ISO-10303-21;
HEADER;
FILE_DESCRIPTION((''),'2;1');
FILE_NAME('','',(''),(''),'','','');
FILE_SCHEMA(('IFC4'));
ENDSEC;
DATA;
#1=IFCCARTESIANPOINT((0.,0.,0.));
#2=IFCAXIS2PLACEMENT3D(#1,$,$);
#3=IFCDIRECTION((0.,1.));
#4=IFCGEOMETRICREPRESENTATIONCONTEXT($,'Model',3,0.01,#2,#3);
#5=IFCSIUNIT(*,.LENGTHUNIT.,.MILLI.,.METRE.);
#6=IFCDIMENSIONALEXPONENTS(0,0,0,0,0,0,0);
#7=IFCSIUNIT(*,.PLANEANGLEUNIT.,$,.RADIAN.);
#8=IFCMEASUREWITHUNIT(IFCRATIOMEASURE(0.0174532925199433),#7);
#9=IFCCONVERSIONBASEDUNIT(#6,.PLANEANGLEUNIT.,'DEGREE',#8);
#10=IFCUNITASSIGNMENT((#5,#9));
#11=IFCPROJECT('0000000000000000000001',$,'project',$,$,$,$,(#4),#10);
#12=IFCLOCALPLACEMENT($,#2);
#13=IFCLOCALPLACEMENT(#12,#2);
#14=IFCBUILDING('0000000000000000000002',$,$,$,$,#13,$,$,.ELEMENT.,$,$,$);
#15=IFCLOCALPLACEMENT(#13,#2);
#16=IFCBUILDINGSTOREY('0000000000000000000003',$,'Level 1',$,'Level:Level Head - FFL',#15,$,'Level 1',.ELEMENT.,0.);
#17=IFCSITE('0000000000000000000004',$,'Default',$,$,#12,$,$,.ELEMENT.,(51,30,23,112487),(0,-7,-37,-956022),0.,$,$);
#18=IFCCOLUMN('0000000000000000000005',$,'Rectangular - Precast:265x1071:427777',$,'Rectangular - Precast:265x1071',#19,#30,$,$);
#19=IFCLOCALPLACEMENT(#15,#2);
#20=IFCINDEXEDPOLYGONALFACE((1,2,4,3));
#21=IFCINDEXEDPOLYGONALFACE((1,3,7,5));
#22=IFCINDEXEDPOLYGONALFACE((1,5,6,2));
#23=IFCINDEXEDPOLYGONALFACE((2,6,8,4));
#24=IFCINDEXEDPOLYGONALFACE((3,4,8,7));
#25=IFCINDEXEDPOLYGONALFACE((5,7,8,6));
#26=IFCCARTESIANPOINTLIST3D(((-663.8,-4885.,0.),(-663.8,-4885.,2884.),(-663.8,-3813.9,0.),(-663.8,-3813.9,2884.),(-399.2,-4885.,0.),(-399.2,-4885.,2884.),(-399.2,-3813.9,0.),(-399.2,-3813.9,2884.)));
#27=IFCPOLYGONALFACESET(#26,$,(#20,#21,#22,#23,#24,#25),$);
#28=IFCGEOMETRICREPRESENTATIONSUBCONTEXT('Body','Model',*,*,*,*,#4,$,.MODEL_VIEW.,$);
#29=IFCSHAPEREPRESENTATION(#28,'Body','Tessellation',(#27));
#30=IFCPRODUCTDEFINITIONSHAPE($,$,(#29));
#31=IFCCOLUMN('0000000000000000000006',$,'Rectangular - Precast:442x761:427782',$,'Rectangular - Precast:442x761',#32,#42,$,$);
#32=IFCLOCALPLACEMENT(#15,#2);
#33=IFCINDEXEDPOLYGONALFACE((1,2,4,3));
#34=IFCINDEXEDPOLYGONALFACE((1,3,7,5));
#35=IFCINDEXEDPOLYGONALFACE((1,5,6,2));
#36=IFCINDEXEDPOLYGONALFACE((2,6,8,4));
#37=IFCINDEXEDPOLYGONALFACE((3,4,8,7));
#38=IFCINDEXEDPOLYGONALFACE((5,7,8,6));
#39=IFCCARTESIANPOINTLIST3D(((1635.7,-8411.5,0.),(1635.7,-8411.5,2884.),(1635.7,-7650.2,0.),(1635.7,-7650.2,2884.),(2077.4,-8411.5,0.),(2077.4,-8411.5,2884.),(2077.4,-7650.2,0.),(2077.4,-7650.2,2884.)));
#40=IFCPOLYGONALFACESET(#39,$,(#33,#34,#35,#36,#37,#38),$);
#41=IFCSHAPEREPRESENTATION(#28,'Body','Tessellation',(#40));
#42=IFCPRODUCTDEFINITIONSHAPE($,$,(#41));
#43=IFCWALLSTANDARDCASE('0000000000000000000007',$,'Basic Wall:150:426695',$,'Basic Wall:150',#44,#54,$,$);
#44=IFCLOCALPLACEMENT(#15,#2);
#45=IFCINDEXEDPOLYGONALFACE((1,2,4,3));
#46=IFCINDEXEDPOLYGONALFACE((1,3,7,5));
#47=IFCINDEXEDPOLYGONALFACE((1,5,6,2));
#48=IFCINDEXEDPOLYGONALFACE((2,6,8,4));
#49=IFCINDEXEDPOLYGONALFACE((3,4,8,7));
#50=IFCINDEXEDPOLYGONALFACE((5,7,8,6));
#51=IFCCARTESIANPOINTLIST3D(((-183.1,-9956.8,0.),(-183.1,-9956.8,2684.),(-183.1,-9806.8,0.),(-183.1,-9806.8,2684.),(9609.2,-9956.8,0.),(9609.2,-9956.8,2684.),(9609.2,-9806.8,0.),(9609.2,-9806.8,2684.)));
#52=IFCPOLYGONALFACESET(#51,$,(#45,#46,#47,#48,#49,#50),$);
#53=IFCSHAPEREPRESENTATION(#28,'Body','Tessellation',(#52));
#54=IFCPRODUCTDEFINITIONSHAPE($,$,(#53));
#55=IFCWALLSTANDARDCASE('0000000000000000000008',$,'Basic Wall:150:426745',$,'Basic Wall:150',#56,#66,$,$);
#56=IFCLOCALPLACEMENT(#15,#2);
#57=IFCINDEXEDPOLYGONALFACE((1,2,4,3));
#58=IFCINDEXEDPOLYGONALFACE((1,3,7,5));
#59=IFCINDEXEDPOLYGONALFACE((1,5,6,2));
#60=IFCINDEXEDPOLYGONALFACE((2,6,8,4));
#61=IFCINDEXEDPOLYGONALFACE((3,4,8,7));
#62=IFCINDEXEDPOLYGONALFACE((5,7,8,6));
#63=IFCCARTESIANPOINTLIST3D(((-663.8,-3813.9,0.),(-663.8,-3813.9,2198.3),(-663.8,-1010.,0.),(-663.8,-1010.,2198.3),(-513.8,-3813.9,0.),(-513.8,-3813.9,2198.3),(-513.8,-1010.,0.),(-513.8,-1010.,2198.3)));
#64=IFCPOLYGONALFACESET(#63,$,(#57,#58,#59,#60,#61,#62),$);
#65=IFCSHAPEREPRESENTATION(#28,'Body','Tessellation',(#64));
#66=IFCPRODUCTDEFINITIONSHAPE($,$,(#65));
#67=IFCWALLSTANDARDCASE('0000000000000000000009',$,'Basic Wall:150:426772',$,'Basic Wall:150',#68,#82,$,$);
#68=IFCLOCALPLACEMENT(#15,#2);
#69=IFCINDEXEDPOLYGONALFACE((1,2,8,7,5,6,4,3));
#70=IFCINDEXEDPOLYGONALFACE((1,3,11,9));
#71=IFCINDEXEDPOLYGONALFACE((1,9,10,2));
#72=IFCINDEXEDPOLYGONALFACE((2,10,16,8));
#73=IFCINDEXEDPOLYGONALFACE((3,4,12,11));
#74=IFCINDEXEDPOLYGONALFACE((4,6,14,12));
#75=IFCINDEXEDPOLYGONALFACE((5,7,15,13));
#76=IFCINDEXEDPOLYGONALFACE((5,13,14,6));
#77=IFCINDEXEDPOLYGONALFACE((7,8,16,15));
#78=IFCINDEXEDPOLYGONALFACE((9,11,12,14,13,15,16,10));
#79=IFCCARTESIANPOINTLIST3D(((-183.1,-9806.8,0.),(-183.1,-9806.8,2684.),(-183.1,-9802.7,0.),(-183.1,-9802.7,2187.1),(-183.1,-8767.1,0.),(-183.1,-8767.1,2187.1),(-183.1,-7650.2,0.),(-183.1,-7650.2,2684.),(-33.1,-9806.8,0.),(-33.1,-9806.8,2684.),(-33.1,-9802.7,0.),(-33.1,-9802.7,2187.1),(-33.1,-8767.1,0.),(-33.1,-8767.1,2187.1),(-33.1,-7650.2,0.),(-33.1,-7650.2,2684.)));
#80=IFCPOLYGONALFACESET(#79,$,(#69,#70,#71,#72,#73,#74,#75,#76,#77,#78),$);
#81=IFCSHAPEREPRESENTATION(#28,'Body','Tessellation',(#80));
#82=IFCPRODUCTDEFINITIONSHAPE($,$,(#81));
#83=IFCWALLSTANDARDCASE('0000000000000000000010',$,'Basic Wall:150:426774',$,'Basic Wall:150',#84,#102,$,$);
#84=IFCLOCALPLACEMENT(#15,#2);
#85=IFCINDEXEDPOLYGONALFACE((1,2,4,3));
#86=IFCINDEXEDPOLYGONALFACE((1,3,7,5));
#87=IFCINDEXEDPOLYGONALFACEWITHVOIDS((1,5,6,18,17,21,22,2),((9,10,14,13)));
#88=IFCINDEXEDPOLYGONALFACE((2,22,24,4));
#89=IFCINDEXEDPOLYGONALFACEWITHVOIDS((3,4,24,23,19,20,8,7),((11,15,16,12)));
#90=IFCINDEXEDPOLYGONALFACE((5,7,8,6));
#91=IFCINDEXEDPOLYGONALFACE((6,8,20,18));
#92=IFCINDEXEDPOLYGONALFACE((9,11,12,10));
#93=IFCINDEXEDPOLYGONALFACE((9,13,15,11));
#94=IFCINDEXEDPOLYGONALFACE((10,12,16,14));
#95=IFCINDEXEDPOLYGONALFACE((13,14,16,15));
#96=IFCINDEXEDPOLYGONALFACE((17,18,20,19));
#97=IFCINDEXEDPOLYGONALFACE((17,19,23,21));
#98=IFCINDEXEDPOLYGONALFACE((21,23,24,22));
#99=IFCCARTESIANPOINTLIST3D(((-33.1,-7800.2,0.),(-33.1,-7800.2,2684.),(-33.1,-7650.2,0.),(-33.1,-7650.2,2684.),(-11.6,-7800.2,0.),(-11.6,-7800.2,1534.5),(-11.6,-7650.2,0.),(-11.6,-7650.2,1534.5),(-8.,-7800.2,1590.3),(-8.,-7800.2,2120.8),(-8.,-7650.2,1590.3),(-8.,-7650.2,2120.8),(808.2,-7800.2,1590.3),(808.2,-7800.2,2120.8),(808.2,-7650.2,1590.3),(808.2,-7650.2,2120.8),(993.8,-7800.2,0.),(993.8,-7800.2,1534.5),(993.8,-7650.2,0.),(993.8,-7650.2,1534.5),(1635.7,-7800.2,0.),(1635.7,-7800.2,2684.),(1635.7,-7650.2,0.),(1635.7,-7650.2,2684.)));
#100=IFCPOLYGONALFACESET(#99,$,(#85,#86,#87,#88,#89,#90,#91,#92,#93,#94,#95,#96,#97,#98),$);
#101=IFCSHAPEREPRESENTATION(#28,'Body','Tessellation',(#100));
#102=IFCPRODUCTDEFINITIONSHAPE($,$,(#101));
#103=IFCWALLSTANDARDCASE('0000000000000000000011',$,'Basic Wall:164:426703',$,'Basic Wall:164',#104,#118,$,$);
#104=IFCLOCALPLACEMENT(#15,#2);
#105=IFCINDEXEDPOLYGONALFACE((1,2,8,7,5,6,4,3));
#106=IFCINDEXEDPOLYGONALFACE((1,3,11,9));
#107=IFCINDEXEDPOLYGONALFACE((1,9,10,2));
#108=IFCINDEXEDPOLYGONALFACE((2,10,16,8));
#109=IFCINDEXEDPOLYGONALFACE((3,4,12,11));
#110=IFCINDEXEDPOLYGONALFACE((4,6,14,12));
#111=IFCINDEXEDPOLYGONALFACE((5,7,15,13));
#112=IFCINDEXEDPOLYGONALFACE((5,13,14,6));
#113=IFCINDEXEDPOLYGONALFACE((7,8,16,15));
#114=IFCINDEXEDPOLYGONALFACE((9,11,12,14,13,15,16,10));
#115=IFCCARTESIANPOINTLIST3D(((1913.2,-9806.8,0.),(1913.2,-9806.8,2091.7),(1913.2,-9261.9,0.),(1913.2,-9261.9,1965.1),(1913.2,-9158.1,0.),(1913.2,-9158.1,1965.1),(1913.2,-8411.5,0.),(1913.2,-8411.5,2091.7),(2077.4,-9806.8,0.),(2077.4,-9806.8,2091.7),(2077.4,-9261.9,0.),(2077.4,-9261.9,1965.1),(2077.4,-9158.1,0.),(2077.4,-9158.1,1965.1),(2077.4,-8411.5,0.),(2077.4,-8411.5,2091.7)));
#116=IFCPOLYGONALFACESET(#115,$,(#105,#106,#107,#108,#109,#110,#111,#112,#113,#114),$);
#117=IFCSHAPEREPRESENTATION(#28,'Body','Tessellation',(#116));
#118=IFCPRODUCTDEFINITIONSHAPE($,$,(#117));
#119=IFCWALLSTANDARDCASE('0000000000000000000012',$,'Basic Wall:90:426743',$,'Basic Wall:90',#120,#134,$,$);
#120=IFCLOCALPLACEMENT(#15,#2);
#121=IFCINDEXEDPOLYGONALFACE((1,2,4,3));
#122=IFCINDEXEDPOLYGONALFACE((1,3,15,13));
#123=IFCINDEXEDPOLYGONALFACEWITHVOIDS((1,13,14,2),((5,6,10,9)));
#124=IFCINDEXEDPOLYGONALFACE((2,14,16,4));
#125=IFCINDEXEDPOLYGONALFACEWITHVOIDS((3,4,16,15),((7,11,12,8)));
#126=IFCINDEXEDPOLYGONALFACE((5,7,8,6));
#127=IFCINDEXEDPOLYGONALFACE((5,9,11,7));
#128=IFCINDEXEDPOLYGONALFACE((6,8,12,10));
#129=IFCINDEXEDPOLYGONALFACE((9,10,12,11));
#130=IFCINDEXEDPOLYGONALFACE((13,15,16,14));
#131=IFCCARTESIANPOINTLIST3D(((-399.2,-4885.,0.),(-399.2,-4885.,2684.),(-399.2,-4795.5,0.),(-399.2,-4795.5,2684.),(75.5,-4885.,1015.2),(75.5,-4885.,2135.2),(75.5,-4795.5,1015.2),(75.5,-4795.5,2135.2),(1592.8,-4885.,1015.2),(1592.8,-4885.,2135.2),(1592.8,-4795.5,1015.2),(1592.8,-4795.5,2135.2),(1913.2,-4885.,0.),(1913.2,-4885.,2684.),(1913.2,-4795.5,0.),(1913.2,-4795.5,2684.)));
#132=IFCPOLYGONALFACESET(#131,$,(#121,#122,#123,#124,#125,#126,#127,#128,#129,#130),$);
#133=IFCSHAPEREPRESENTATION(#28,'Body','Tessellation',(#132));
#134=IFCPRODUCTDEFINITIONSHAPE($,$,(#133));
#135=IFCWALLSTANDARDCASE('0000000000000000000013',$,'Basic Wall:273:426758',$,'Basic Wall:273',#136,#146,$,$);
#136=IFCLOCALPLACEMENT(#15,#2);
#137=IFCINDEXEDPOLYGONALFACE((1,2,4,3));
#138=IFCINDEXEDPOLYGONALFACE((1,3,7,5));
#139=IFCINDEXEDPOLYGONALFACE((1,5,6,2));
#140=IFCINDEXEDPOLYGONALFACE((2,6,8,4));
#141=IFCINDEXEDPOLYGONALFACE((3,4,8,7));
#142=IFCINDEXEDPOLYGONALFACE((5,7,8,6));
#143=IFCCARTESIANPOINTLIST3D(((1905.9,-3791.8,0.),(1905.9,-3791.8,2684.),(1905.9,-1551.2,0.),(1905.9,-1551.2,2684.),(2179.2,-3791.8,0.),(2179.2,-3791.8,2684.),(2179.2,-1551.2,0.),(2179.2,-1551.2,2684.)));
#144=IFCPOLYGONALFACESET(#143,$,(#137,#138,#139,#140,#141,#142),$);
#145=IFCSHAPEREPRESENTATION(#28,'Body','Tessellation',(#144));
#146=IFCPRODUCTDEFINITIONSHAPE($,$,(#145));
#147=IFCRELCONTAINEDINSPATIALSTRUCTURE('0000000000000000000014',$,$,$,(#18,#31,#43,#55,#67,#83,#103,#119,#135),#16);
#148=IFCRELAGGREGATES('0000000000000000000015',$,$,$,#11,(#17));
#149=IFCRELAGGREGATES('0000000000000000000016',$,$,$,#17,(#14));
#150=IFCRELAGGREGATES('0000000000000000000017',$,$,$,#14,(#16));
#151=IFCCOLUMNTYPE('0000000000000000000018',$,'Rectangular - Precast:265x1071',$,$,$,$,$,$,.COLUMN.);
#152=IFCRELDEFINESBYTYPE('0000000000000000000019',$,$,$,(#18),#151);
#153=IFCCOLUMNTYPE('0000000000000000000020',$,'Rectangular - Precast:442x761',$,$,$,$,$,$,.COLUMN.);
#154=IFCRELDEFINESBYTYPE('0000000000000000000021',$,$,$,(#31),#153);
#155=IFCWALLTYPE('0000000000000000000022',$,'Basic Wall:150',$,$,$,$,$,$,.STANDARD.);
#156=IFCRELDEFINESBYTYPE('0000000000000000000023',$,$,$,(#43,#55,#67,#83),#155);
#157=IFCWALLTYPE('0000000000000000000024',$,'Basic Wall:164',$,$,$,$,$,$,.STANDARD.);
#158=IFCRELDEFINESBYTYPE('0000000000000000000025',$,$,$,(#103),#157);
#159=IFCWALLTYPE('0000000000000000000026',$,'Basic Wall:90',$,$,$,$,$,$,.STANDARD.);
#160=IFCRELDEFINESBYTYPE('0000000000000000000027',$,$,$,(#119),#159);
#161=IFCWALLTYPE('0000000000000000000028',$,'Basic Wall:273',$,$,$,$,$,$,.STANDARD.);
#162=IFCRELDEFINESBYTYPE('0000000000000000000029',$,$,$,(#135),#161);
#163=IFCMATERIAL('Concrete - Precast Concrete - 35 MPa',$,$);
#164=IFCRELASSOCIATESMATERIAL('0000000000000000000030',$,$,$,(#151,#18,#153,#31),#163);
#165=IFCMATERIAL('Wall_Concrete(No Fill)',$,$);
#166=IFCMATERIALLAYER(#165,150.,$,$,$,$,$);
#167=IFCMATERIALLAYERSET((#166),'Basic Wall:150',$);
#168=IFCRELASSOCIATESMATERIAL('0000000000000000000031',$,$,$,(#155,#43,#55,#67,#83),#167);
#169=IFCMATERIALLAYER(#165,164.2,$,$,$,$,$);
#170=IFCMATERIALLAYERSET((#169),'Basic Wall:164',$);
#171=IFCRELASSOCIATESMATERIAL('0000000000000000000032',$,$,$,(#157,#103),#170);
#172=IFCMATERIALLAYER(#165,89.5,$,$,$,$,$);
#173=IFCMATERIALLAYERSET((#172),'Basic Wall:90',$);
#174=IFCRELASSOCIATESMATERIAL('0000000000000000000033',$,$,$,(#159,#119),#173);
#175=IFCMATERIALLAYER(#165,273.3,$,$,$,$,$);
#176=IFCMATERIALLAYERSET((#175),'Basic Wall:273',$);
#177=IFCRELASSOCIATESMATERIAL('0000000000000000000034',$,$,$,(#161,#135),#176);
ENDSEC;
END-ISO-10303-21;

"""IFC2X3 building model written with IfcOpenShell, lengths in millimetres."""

from ifc_helpers import new_model, entity, si_unit, converted_unit, direction, frame, frame_2d, origin, origin_2d_with_axis, place, context, subcontext, project, spatial, rectangle, extrude, source, transform, mapped, material, layer, layer_set, layer_usage, type_object, type_shapes, element, save


model = new_model("IFC2X3")

# Units and contexts
model_context = context("Model", 3, precision=0.01, world=origin(), true_north=direction((0.0, 1.0)))
body_context = subcontext(model_context, "Body", "Model", "MODEL_VIEW")
ifc_project = project(units=[si_unit("LENGTHUNIT", "METRE", prefix="MILLI"), converted_unit("PLANEANGLEUNIT", "DEGREE", entity("IfcRatioMeasure", 0.0174532925199433), si_unit("PLANEANGLEUNIT", "RADIAN"), dimensions=[0, 0, 0, 0, 0, 0, 0])], contexts=[model_context])

# Site, building, storey
site_placement = place(None, origin())
site = spatial("IfcSite", under=ifc_project, at=site_placement, Name="Default", CompositionType="ELEMENT", RefLatitude=(51, 30, 23, 112487), RefLongitude=(0, -7, -37, -956022), RefElevation=0.0)
building_placement = place(site_placement, origin())
building = spatial("IfcBuilding", under=site, at=building_placement, CompositionType="ELEMENT")
storey_placement = place(building_placement, origin())
storey = spatial("IfcBuildingStorey", under=building, at=storey_placement, Name="Level 1", ObjectType="Level:Level Head - FFL", LongName="Level 1", CompositionType="ELEMENT", Elevation=0.0)

# Columns
ifc_material_1 = material(Name="Concrete - Precast Concrete - 35 MPa")
column_type_1 = type_object("IfcColumnType", Name="Rectangular - Precast:265x1071", PredefinedType="COLUMN", material=ifc_material_1)
shared_shape_1 = source(origin(), body_context, "Body", "SweptSolid", [
    extrude(rectangle(XDim=1071.1, YDim=264.6, at=frame_2d((0.0, 0.0), x_axis=(1.0, 0.0))), frame((0.0, 0.0, 0.0), z_axis=(0.0, 0.0, 1.0), x_axis=(0.0, -1.0, 0.0)), (0.0, 0.0, 1.0), 2884.0),
])
type_shapes(column_type_1, [shared_shape_1])
column_1_placement = place(storey_placement, frame((-531.5, -4349.4, 0.0)))
element("IfcColumn", 1, at=column_1_placement, inside=storey, type_object=column_type_1, material=ifc_material_1, Name="Rectangular - Precast:265x1071:427777", ObjectType="Rectangular - Precast:265x1071", context=body_context, shape_type="MappedRepresentation", body=[
    mapped(shared_shape_1, transform((0.0, 0.0, 0.0), scale=1.0)),
])
column_type_2 = type_object("IfcColumnType", Name="Rectangular - Precast:442x761", PredefinedType="COLUMN", material=ifc_material_1)
shared_shape_2 = source(origin(), body_context, "Body", "SweptSolid", [
    extrude(rectangle(XDim=761.3, YDim=441.8, at=frame_2d((0.0, 0.0), x_axis=(1.0, 0.0))), frame((0.0, 0.0, 0.0), z_axis=(0.0, 0.0, 1.0), x_axis=(0.0, -1.0, 0.0)), (0.0, 0.0, 1.0), 2884.0),
])
type_shapes(column_type_2, [shared_shape_2])
column_2_placement = place(storey_placement, frame((1856.6, -8030.8, 0.0)))
element("IfcColumn", 2, at=column_2_placement, inside=storey, type_object=column_type_2, material=ifc_material_1, Name="Rectangular - Precast:442x761:427782", ObjectType="Rectangular - Precast:442x761", context=body_context, shape_type="MappedRepresentation", body=[
    mapped(shared_shape_2, transform((0.0, 0.0, 0.0), scale=1.0)),
])

# Shared definitions
ifc_material_2 = material(Name="Wall_Concrete(No Fill)")

# Wall
ifc_layer_1 = layer(ifc_material_2, 150.0)
ifc_layer_set_1 = layer_set([ifc_layer_1], Name="Basic Wall:150")
ifc_layer_usage_1 = layer_usage(ifc_layer_set_1, "AXIS2", "NEGATIVE", 75.0)
wall_type_1 = type_object("IfcWallType", Name="Basic Wall:150", PredefinedType="STANDARD", material=ifc_layer_set_1)
wall_1_placement = place(storey_placement, frame((-183.1, -9881.8, 0.0)))
element("IfcWallStandardCase", 3, at=wall_1_placement, inside=storey, type_object=wall_type_1, material=ifc_layer_usage_1, Name="Basic Wall:150:426695", ObjectType="Basic Wall:150", context=body_context, shape_type="SweptSolid", body=[
    extrude(rectangle(XDim=9792.4, YDim=150.0, at=frame_2d((4896.2, 0.0), x_axis=(-1.0, 0.0))), origin(), (0.0, 0.0, 1.0), 2684.0),
])

# Walls, openings
ifc_layer_usage_2 = layer_usage(ifc_layer_set_1, "AXIS2", "NEGATIVE", 75.0)
wall_2_placement = place(storey_placement, frame((-588.8, -3813.9, 0.0), z_axis=(0.0, 0.0, 1.0), x_axis=(0.0, 1.0, 0.0)))
wall_2 = element("IfcWallStandardCase", 4, at=wall_2_placement, inside=storey, type_object=wall_type_1, material=ifc_layer_usage_2, Name="Basic Wall:150:426745", ObjectType="Basic Wall:150", context=body_context, shape_type="SweptSolid", body=[
    extrude(rectangle(XDim=2803.9, YDim=150.0, at=frame_2d((1401.9, 0.0), x_axis=(-1.0, 0.0))), origin(), (0.0, 0.0, 1.0), 2198.3),
])
opening_1_placement = place(wall_2_placement, origin())
element("IfcOpeningElement", 5, at=opening_1_placement, cuts=wall_2, ObjectType="Opening", context=body_context, shape_type="SweptSolid", body=[
    extrude(rectangle(XDim=685.7, YDim=2803.9, at=frame_2d((0.0, 0.0), x_axis=(1.0, 0.0))), frame((1401.9, -75.0, 2541.2), z_axis=(0.0, 1.0, 0.0), x_axis=(0.0, 0.0, -1.0)), (0.0, 0.0, 1.0), 150.0),
])
ifc_layer_usage_3 = layer_usage(ifc_layer_set_1, "AXIS2", "NEGATIVE", 75.0)
wall_3_placement = place(storey_placement, frame((-108.1, -9806.8, 0.0), z_axis=(0.0, 0.0, 1.0), x_axis=(0.0, 1.0, 0.0)))
wall_3 = element("IfcWallStandardCase", 6, at=wall_3_placement, inside=storey, type_object=wall_type_1, material=ifc_layer_usage_3, Name="Basic Wall:150:426772", ObjectType="Basic Wall:150", context=body_context, shape_type="SweptSolid", body=[
    extrude(rectangle(XDim=2156.7, YDim=150.0, at=frame_2d((1078.3, 0.0), x_axis=(-1.0, 0.0))), origin(), (0.0, 0.0, 1.0), 2684.0),
])
opening_2_placement = place(wall_3_placement, origin())
element("IfcOpeningElement", 7, at=opening_2_placement, cuts=wall_3, ObjectType="Opening", context=body_context, shape_type="SweptSolid", body=[
    extrude(rectangle(XDim=2187.1, YDim=1035.6, at=origin_2d_with_axis()), frame((521.9, -75.0, 1093.5), z_axis=(0.0, 1.0, 0.0), x_axis=(0.0, 0.0, -1.0)), (0.0, 0.0, 1.0), 150.0),
])

# Walls, openings
ifc_layer_usage_4 = layer_usage(ifc_layer_set_1, "AXIS2", "NEGATIVE", 75.0)
wall_4_placement = place(storey_placement, frame((-33.1, -7725.2, 0.0)))
wall_4 = element("IfcWallStandardCase", 8, at=wall_4_placement, inside=storey, type_object=wall_type_1, material=ifc_layer_usage_4, Name="Basic Wall:150:426774", ObjectType="Basic Wall:150", context=body_context, shape_type="SweptSolid", body=[
    extrude(rectangle(XDim=1668.8, YDim=150.0, at=frame_2d((834.4, 0.0), x_axis=(-1.0, 0.0))), origin(), (0.0, 0.0, 1.0), 2684.0),
])
opening_3_placement = place(wall_4_placement, origin())
element("IfcOpeningElement", 9, at=opening_3_placement, cuts=wall_4, ObjectType="Opening", context=body_context, shape_type="SweptSolid", body=[
    extrude(rectangle(XDim=1534.5, YDim=1005.4, at=origin_2d_with_axis()), frame((524.2, -75.0, 767.2), z_axis=(0.0, 1.0, 0.0), x_axis=(0.0, 0.0, -1.0)), (0.0, 0.0, 1.0), 150.0),
])
opening_4_placement = place(wall_4_placement, origin())
element("IfcOpeningElement", 10, at=opening_4_placement, cuts=wall_4, ObjectType="Opening", context=body_context, shape_type="SweptSolid", body=[
    extrude(rectangle(XDim=530.5, YDim=816.3, at=frame_2d((0.0, 0.0), x_axis=(1.0, 0.0))), frame((433.2, -75.0, 1855.5), z_axis=(0.0, 1.0, 0.0), x_axis=(0.0, 0.0, -1.0)), (0.0, 0.0, 1.0), 150.0),
])
ifc_layer_2 = layer(ifc_material_2, 164.2)
ifc_layer_set_2 = layer_set([ifc_layer_2], Name="Basic Wall:164")
ifc_layer_usage_5 = layer_usage(ifc_layer_set_2, "AXIS2", "NEGATIVE", 82.1)
wall_type_2 = type_object("IfcWallType", Name="Basic Wall:164", PredefinedType="STANDARD", material=ifc_layer_set_2)
wall_5_placement = place(storey_placement, frame((1995.3, -9806.8, 0.0), z_axis=(0.0, 0.0, 1.0), x_axis=(0.0, 1.0, 0.0)))
wall_5 = element("IfcWallStandardCase", 11, at=wall_5_placement, inside=storey, type_object=wall_type_2, material=ifc_layer_usage_5, Name="Basic Wall:164:426703", ObjectType="Basic Wall:164", context=body_context, shape_type="SweptSolid", body=[
    extrude(rectangle(XDim=1395.3, YDim=164.2, at=frame_2d((697.7, 0.0), x_axis=(-1.0, 0.0))), origin(), (0.0, 0.0, 1.0), 2091.7),
])
opening_5_placement = place(wall_5_placement, origin())
element("IfcOpeningElement", 12, at=opening_5_placement, cuts=wall_5, ObjectType="Opening", context=body_context, shape_type="SweptSolid", body=[
    extrude(rectangle(XDim=792.3, YDim=1395.3, at=origin_2d_with_axis()), frame((697.7, -82.1, 2487.8), z_axis=(0.0, 1.0, 0.0), x_axis=(0.0, 0.0, -1.0)), (0.0, 0.0, 1.0), 164.2),
])
opening_6_placement = place(wall_5_placement, origin())
element("IfcOpeningElement", 13, at=opening_6_placement, cuts=wall_5, ObjectType="Opening", context=body_context, shape_type="SweptSolid", body=[
    extrude(rectangle(XDim=1965.1, YDim=103.9, at=origin_2d_with_axis()), frame((596.8, -82.1, 982.5), z_axis=(0.0, 1.0, 0.0), x_axis=(0.0, 0.0, -1.0)), (0.0, 0.0, 1.0), 164.2),
])

# Wall, opening
ifc_layer_3 = layer(ifc_material_2, 89.5)
ifc_layer_set_3 = layer_set([ifc_layer_3], Name="Basic Wall:90")
ifc_layer_usage_6 = layer_usage(ifc_layer_set_3, "AXIS2", "NEGATIVE", 44.8)
wall_type_3 = type_object("IfcWallType", Name="Basic Wall:90", PredefinedType="STANDARD", material=ifc_layer_set_3)
wall_6_placement = place(storey_placement, frame((-399.2, -4840.2, 0.0)))
wall_6 = element("IfcWallStandardCase", 14, at=wall_6_placement, inside=storey, type_object=wall_type_3, material=ifc_layer_usage_6, Name="Basic Wall:90:426743", ObjectType="Basic Wall:90", context=body_context, shape_type="SweptSolid", body=[
    extrude(rectangle(XDim=2312.4, YDim=89.5, at=frame_2d((1156.2, 0.0), x_axis=(-1.0, 0.0))), origin(), (0.0, 0.0, 1.0), 2684.0),
])
opening_7_placement = place(wall_6_placement, origin())
element("IfcOpeningElement", 15, at=opening_7_placement, cuts=wall_6, ObjectType="Opening", context=body_context, shape_type="SweptSolid", body=[
    extrude(rectangle(XDim=1120.0, YDim=1517.3, at=frame_2d((0.0, 0.0), x_axis=(1.0, 0.0))), frame((1233.4, -44.8, 1575.2), z_axis=(0.0, 1.0, 0.0), x_axis=(0.0, 0.0, -1.0)), (0.0, 0.0, 1.0), 89.5),
])

# Wall
ifc_layer_4 = layer(ifc_material_2, 273.3)
ifc_layer_set_4 = layer_set([ifc_layer_4], Name="Basic Wall:273")
ifc_layer_usage_7 = layer_usage(ifc_layer_set_4, "AXIS2", "NEGATIVE", 136.6)
wall_type_4 = type_object("IfcWallType", Name="Basic Wall:273", PredefinedType="STANDARD", material=ifc_layer_set_4)
wall_7_placement = place(storey_placement, frame((2042.6, -3791.8, 0.0), z_axis=(0.0, 0.0, 1.0), x_axis=(0.0, 1.0, 0.0)))
element("IfcWallStandardCase", 16, at=wall_7_placement, inside=storey, type_object=wall_type_4, material=ifc_layer_usage_7, Name="Basic Wall:273:426758", ObjectType="Basic Wall:273", context=body_context, shape_type="SweptSolid", body=[
    extrude(rectangle(XDim=2240.6, YDim=273.3, at=frame_2d((1120.3, 0.0), x_axis=(-1.0, 0.0))), origin(), (0.0, 0.0, 1.0), 2684.0),
])

save(model, "model.ifc")
